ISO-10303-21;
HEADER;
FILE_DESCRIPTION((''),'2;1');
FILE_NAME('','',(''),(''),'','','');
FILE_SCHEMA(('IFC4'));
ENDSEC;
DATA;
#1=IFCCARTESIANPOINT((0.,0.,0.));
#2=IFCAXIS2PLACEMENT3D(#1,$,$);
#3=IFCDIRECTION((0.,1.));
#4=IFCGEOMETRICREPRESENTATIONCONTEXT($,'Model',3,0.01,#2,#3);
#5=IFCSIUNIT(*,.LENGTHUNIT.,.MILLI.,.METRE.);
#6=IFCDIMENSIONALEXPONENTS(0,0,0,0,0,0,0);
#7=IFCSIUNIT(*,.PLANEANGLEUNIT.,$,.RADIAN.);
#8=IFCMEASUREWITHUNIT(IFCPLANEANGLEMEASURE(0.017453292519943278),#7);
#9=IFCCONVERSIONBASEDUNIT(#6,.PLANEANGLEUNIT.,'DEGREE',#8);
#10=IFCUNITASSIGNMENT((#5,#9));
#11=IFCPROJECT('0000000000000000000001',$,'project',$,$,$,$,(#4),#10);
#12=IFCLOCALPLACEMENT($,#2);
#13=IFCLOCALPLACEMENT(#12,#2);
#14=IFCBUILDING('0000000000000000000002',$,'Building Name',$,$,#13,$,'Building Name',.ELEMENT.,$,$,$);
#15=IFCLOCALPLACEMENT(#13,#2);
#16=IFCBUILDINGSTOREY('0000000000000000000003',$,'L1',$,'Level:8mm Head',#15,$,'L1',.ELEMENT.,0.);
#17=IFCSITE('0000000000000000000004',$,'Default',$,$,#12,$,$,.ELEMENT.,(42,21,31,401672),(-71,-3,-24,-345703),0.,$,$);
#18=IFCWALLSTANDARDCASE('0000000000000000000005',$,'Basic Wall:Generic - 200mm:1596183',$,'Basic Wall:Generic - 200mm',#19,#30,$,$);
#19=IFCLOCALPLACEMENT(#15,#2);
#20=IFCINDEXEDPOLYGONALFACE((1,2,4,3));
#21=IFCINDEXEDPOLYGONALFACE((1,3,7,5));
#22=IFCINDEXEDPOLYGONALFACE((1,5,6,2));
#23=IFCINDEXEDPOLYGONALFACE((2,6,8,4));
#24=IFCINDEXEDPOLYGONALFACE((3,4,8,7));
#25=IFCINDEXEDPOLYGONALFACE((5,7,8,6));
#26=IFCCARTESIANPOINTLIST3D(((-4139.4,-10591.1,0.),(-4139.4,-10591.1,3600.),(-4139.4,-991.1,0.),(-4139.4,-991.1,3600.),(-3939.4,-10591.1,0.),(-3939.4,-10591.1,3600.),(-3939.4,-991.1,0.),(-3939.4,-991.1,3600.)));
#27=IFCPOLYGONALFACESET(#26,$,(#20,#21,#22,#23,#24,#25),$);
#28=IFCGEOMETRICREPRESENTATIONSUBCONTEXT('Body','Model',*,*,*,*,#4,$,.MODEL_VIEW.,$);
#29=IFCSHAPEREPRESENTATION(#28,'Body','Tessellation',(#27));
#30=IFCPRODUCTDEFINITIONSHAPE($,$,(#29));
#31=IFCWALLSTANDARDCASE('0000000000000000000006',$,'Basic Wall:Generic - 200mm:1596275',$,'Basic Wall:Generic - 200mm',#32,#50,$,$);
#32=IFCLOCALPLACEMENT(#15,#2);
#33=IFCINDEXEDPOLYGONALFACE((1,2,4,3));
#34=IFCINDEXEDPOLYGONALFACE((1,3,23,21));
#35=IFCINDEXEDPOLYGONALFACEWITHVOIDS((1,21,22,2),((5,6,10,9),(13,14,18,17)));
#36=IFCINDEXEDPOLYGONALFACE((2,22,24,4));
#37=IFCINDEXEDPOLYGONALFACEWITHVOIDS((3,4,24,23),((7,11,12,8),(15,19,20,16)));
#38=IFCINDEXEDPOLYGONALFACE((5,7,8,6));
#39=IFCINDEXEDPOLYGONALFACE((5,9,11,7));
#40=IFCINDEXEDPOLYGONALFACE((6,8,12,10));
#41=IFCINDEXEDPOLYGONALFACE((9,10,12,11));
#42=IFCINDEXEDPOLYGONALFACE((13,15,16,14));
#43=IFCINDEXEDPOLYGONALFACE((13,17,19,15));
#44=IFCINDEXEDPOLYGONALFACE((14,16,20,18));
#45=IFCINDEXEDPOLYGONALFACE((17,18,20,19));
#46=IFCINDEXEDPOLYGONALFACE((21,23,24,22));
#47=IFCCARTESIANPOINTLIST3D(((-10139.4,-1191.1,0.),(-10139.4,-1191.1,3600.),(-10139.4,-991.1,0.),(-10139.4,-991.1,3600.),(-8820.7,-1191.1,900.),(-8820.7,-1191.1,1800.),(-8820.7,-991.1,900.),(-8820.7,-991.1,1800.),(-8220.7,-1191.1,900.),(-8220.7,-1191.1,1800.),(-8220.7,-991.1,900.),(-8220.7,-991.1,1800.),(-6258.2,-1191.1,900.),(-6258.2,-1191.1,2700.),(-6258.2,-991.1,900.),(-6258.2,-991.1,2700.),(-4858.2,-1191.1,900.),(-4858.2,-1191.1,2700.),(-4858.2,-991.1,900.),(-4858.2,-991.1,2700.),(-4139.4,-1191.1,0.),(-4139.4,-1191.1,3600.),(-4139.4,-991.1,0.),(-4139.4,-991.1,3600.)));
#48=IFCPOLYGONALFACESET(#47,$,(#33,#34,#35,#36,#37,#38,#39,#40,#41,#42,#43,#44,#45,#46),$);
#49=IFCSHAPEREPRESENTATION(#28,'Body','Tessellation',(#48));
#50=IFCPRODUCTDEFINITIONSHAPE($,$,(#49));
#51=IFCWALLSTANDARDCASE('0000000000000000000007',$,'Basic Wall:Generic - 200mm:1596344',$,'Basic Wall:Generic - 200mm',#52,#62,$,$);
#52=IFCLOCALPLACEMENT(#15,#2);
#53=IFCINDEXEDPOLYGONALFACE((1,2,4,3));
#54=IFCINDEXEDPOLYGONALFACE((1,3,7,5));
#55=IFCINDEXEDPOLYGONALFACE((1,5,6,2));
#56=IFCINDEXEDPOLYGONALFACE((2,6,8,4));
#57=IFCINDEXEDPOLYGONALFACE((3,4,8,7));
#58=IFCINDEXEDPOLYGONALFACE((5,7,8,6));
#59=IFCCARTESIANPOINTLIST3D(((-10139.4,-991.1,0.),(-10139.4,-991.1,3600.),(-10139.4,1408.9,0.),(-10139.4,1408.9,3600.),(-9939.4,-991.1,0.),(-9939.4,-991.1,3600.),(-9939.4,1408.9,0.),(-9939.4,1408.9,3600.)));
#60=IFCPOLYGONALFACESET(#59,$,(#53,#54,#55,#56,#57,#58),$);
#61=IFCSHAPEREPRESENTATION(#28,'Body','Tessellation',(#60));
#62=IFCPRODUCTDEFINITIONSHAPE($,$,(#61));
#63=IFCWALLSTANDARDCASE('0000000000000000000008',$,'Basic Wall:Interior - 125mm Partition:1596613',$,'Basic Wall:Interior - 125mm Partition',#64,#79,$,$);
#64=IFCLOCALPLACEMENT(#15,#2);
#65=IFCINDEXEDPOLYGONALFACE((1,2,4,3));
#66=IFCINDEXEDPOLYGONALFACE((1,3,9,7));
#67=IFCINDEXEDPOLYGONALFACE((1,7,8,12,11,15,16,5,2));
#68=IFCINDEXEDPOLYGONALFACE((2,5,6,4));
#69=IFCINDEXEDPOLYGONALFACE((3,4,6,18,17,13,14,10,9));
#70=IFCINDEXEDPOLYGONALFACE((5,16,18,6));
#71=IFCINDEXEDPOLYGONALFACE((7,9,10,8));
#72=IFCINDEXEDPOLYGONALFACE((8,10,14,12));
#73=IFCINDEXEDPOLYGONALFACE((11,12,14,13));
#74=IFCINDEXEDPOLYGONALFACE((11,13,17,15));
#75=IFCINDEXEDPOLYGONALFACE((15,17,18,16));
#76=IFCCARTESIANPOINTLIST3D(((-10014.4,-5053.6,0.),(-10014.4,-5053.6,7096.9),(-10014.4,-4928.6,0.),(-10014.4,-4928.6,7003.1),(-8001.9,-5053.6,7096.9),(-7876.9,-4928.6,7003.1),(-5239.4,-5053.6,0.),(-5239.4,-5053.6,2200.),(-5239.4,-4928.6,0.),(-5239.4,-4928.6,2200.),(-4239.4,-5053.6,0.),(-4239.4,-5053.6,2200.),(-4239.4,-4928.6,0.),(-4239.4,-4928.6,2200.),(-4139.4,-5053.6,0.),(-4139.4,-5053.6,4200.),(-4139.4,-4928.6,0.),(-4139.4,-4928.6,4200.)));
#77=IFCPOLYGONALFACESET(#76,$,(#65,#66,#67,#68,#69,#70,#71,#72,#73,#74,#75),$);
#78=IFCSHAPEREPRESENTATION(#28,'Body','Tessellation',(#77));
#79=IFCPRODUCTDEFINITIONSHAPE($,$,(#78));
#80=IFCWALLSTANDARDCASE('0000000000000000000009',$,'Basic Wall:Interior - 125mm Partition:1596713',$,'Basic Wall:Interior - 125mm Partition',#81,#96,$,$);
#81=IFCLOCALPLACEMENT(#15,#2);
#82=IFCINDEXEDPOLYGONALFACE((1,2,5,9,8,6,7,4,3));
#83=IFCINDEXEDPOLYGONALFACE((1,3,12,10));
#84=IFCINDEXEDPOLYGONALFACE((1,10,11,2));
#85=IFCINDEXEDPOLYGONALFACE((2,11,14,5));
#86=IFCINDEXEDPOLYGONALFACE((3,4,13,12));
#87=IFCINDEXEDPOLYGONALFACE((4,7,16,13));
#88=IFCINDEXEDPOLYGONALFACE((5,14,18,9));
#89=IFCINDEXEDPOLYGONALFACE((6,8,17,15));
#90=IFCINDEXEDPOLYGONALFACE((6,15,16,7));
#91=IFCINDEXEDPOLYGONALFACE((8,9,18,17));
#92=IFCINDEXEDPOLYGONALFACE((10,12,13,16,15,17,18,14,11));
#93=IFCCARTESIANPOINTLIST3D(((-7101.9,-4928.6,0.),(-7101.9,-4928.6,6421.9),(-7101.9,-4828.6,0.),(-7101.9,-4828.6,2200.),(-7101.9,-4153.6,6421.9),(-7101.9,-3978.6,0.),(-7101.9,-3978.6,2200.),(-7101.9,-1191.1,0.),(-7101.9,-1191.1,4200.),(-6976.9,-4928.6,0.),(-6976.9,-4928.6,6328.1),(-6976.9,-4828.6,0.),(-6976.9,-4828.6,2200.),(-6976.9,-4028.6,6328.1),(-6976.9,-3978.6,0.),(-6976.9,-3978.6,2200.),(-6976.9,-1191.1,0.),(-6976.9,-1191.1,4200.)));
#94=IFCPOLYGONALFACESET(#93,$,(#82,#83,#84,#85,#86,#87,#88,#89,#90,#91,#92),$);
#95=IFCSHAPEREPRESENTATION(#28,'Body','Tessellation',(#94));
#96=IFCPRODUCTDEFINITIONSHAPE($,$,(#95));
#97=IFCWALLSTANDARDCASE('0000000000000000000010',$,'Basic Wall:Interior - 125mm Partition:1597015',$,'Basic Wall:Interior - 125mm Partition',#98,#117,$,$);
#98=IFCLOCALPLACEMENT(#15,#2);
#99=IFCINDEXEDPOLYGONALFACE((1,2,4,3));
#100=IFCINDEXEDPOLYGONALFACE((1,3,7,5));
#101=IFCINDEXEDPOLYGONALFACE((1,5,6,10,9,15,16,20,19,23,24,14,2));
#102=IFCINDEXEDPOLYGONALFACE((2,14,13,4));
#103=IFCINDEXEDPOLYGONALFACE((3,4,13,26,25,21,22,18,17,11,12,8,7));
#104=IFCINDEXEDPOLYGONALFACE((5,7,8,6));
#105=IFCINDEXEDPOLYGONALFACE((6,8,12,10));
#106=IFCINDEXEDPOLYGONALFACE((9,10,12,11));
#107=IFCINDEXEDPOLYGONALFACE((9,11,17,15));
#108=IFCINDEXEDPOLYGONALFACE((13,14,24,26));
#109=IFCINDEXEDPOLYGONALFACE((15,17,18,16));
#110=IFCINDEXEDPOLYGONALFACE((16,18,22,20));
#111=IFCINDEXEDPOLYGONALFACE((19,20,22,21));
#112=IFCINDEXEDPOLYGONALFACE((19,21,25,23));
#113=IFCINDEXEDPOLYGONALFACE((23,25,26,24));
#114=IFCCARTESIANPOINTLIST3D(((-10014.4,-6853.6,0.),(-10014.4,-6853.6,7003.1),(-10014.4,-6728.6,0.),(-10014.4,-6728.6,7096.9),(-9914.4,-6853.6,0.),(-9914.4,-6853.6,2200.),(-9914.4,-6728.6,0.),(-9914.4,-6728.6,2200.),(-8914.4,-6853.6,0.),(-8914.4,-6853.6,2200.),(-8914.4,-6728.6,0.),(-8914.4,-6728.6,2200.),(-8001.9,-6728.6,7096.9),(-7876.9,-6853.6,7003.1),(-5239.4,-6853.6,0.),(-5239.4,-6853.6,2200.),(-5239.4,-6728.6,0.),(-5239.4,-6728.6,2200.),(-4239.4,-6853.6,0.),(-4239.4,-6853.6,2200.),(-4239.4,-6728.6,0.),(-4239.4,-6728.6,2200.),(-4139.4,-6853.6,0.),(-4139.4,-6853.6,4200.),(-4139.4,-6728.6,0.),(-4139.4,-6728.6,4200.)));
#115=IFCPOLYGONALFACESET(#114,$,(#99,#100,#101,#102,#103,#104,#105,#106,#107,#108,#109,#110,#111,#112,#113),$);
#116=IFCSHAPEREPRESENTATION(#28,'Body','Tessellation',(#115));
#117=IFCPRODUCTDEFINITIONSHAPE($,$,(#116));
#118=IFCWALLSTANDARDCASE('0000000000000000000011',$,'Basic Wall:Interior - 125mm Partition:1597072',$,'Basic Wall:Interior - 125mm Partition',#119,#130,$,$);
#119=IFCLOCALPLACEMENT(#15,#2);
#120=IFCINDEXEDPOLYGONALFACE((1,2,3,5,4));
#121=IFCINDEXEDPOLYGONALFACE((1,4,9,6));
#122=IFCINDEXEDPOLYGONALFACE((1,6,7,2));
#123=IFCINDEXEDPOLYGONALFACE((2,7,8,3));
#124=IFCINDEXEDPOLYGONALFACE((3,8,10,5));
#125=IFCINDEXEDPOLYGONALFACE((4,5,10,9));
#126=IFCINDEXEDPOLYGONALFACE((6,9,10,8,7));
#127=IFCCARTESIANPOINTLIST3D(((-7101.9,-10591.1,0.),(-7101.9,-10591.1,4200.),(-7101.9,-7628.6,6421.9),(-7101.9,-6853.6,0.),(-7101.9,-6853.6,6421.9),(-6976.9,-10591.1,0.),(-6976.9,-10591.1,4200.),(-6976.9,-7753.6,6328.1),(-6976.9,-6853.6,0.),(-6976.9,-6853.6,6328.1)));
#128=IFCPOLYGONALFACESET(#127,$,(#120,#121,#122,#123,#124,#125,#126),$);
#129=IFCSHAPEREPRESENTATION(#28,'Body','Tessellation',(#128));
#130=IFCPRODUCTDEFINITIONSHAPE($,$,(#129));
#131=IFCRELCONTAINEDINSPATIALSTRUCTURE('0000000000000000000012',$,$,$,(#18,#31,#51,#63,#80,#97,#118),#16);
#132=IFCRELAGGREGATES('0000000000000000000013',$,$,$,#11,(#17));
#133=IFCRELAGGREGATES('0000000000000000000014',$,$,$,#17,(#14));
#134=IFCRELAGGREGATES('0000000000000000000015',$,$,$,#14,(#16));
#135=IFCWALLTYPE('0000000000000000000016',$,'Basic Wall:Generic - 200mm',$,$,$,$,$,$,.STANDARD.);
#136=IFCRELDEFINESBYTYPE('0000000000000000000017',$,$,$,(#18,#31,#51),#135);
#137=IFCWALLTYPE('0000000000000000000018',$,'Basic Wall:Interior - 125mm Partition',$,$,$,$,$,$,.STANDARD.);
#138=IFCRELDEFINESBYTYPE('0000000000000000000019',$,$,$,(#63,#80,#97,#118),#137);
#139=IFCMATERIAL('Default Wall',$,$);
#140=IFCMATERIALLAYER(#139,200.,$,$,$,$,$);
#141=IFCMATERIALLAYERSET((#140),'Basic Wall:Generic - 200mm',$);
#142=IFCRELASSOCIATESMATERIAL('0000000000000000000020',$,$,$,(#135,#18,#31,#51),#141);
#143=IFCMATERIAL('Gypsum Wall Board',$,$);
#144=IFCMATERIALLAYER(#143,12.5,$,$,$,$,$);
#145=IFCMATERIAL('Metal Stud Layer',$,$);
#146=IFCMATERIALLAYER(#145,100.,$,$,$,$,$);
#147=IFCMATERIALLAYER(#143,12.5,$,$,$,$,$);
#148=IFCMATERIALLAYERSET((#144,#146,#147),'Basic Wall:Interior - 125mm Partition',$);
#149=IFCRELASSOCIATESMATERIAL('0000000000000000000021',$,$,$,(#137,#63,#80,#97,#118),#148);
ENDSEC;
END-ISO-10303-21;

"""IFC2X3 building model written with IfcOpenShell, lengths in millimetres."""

from ifc_helpers import new_model, entity, si_unit, converted_unit, direction, frame, frame_2d, origin, place, context, subcontext, project, spatial, polyline, rectangle, extrude, clip, bounded_halfspace, material, layer, layer_set, layer_usage, type_object, element, save


model = new_model("IFC2X3")

# Units and contexts
model_context = context("Model", 3, precision=0.01, world=origin(), true_north=direction((0.0, 1.0)))
body_context = subcontext(model_context, "Body", "Model", "MODEL_VIEW")
ifc_project = project(units=[si_unit("LENGTHUNIT", "METRE", prefix="MILLI"), converted_unit("PLANEANGLEUNIT", "DEGREE", entity("IfcPlaneAngleMeasure", 0.017453292519943278), si_unit("PLANEANGLEUNIT", "RADIAN"), dimensions=[0, 0, 0, 0, 0, 0, 0])], contexts=[model_context])

# Site, building, storey
site_placement = place(None, origin())
site = spatial("IfcSite", under=ifc_project, at=site_placement, Name="Default", CompositionType="ELEMENT", RefLatitude=(42, 21, 31, 401672), RefLongitude=(-71, -3, -24, -345703), RefElevation=0.0)
building_placement = place(site_placement, origin())
building = spatial("IfcBuilding", under=site, at=building_placement, Name="Building Name", LongName="Building Name", CompositionType="ELEMENT")
storey_placement = place(building_placement, origin())
storey = spatial("IfcBuildingStorey", under=building, at=storey_placement, Name="L1", ObjectType="Level:8mm Head", LongName="L1", CompositionType="ELEMENT", Elevation=0.0)

# Wall
ifc_material_1 = material(Name="Default Wall")
ifc_layer_1 = layer(ifc_material_1, 200.0)
ifc_layer_set_1 = layer_set([ifc_layer_1], Name="Basic Wall:Generic - 200mm")
ifc_layer_usage_1 = layer_usage(ifc_layer_set_1, "AXIS2", "NEGATIVE", 100.0)
wall_type_1 = type_object("IfcWallType", Name="Basic Wall:Generic - 200mm", PredefinedType="STANDARD", material=ifc_layer_set_1)
wall_1_placement = place(storey_placement, frame((-4039.4, -10591.1, 0.0), z_axis=(0.0, 0.0, 1.0), x_axis=(0.0, 1.0, 0.0)))
element("IfcWallStandardCase", 1, at=wall_1_placement, inside=storey, type_object=wall_type_1, material=ifc_layer_usage_1, Name="Basic Wall:Generic - 200mm:1596183", ObjectType="Basic Wall:Generic - 200mm", context=body_context, shape_type="SweptSolid", body=[
    extrude(rectangle(XDim=9600.0, YDim=200.0, at=frame_2d((4800.0, 0.0), x_axis=(-1.0, 0.0))), origin(), (0.0, 0.0, 1.0), 3600.0),
])

# Wall, openings
wall_2_placement = place(storey_placement, frame((-4139.4, -1091.1, 0.0), z_axis=(0.0, 0.0, 1.0), x_axis=(-1.0, 0.0, 0.0)))
wall_2 = element("IfcWallStandardCase", 2, at=wall_2_placement, inside=storey, type_object=wall_type_1, material=ifc_layer_usage_1, Name="Basic Wall:Generic - 200mm:1596275", ObjectType="Basic Wall:Generic - 200mm", context=body_context, shape_type="SweptSolid", body=[
    extrude(rectangle(XDim=6000.0, YDim=200.0, at=frame_2d((3000.0, 0.0), x_axis=(-1.0, 0.0))), origin(), (0.0, 0.0, 1.0), 3600.0),
])
opening_1_placement = place(wall_2_placement, frame((2118.8, 100.0, 900.0)))
element("IfcOpeningElement", 3, at=opening_1_placement, cuts=wall_2, ObjectType="Opening", context=body_context, shape_type="SweptSolid", body=[
    extrude(rectangle(XDim=1800.0, YDim=1400.0, at=frame_2d((900.0, 700.0), x_axis=(-1.0, 0.0))), frame((0.0, 0.0, 0.0), z_axis=(0.0, -1.0, 0.0), x_axis=(0.0, 0.0, 1.0)), (0.0, 0.0, 1.0), 200.0),
])
opening_2_placement = place(wall_2_placement, frame((4081.3, -100.0, 900.0)))
element("IfcOpeningElement", 4, at=opening_2_placement, cuts=wall_2, ObjectType="Opening", context=body_context, shape_type="SweptSolid", body=[
    extrude(rectangle(XDim=900.0, YDim=600.0, at=frame_2d((450.0, 300.0), x_axis=(-1.0, 0.0))), frame((0.0, 0.0, 0.0), z_axis=(0.0, 1.0, 0.0), x_axis=(0.0, 0.0, 1.0)), (0.0, 0.0, 1.0), 200.0),
])

# Wall
wall_3_placement = place(storey_placement, frame((-10039.4, -991.1, 0.0), z_axis=(0.0, 0.0, 1.0), x_axis=(0.0, 1.0, 0.0)))
element("IfcWallStandardCase", 5, at=wall_3_placement, inside=storey, type_object=wall_type_1, material=ifc_layer_usage_1, Name="Basic Wall:Generic - 200mm:1596344", ObjectType="Basic Wall:Generic - 200mm", context=body_context, shape_type="SweptSolid", body=[
    extrude(rectangle(XDim=2400.0, YDim=200.0, at=frame_2d((1200.0, 0.0), x_axis=(-1.0, 0.0))), origin(), (0.0, 0.0, 1.0), 3600.0),
])

# Walls, openings
ifc_material_2 = material(Name="Gypsum Wall Board")
ifc_layer_2 = layer(ifc_material_2, 12.5)
ifc_material_3 = material(Name="Metal Stud Layer")
ifc_layer_3 = layer(ifc_material_3, 100.0)
ifc_layer_4 = layer(ifc_material_2, 12.5)
ifc_layer_set_2 = layer_set([ifc_layer_2, ifc_layer_3, ifc_layer_4], Name="Basic Wall:Interior - 125mm Partition")
ifc_layer_usage_2 = layer_usage(ifc_layer_set_2, "AXIS2", "NEGATIVE", 62.5)
wall_type_2 = type_object("IfcWallType", Name="Basic Wall:Interior - 125mm Partition", PredefinedType="STANDARD", material=ifc_layer_set_2)
wall_4_placement = place(storey_placement, frame((-10014.4, -4991.1, 0.0)))
wall_4 = element("IfcWallStandardCase", 6, at=wall_4_placement, inside=storey, type_object=wall_type_2, material=ifc_layer_usage_2, Name="Basic Wall:Interior - 125mm Partition:1596613", ObjectType="Basic Wall:Interior - 125mm Partition", context=body_context, shape_type="Clipping", body=[
    clip(clip(extrude(rectangle(XDim=125.0, YDim=5875.0, at=frame_2d((2937.5, 0.0), x_axis=(0.0, 1.0))), origin(), (0.0, 0.0, 1.0), 7096.9), bounded_halfspace(frame((5875.0, -62.5, 4200.0), z_axis=(0.6, 0.0, 0.8), x_axis=(0.0, 1.0, 0.0)), False, frame((5875.0, -62.5, 4200.0)), polyline([(0.0, 0.0), (0.0, 125.0), (-2837.5, 125.0), (-2962.5, 125.0), (-3737.5, 125.0), (-3862.5, 0.0), (0.0, 0.0)]))), bounded_halfspace(frame((0.0, 62.5, 7003.1), z_axis=(0.0, 0.6, 0.8), x_axis=(-1.0, 0.0, 0.0)), False, frame((0.0, 62.5, 7003.1)), polyline([(0.0, 0.0), (0.0, -125.0), (2012.5, -125.0), (2137.5, 0.0), (0.0, 0.0)]))),
])
opening_3_placement = place(wall_4_placement, frame((4775.0, -62.5, 0.0)))
element("IfcOpeningElement", 7, at=opening_3_placement, cuts=wall_4, ObjectType="Opening", context=body_context, shape_type="SweptSolid", body=[
    extrude(rectangle(XDim=2200.0, YDim=1000.0, at=frame_2d((1100.0, 500.0), x_axis=(1.0, 0.0))), frame((0.0, 0.0, 0.0), z_axis=(0.0, 1.0, 0.0), x_axis=(0.0, 0.0, 1.0)), (0.0, 0.0, 1.0), 125.0),
])
wall_5_placement = place(storey_placement, frame((-7039.4, -4928.6, 0.0), z_axis=(0.0, 0.0, 1.0), x_axis=(0.0, 1.0, 0.0)))
wall_5 = element("IfcWallStandardCase", 8, at=wall_5_placement, inside=storey, type_object=wall_type_2, material=ifc_layer_usage_2, Name="Basic Wall:Interior - 125mm Partition:1596713", ObjectType="Basic Wall:Interior - 125mm Partition", context=body_context, shape_type="Clipping", body=[
    clip(clip(extrude(rectangle(XDim=125.0, YDim=3737.5, at=frame_2d((1868.8, 0.0), x_axis=(0.0, 1.0))), origin(), (0.0, 0.0, 1.0), 6421.9), bounded_halfspace(frame((0.0, 62.5, 6421.9), z_axis=(0.0, -0.6, 0.8), x_axis=(1.0, 0.0, 0.0)), False, frame((0.0, 62.5, 6421.9)), polyline([(0.0, 0.0), (0.0, -125.0), (900.0, -125.0), (775.0, 0.0), (0.0, 0.0)]))), bounded_halfspace(frame((3737.5, -62.5, 4200.0), z_axis=(0.6, 0.0, 0.8), x_axis=(0.0, 1.0, 0.0)), False, frame((3737.5, -62.5, 4200.0)), polyline([(0.0, 0.0), (0.0, 125.0), (-2962.5, 125.0), (-2837.5, 0.0), (0.0, 0.0)]))),
])
opening_4_placement = place(wall_5_placement, frame((100.0, -62.5, 0.0)))
element("IfcOpeningElement", 9, at=opening_4_placement, cuts=wall_5, ObjectType="Opening", context=body_context, shape_type="SweptSolid", body=[
    extrude(rectangle(XDim=2200.0, YDim=850.0, at=frame_2d((1100.0, 425.0), x_axis=(1.0, 0.0))), frame((0.0, 0.0, 0.0), z_axis=(0.0, 1.0, 0.0), x_axis=(0.0, 0.0, 1.0)), (0.0, 0.0, 1.0), 125.0),
])

# Wall, openings
wall_6_placement = place(storey_placement, frame((-10014.4, -6791.1, 0.0)))
wall_6 = element("IfcWallStandardCase", 10, at=wall_6_placement, inside=storey, type_object=wall_type_2, material=ifc_layer_usage_2, Name="Basic Wall:Interior - 125mm Partition:1597015", ObjectType="Basic Wall:Interior - 125mm Partition", context=body_context, shape_type="Clipping", body=[
    clip(clip(extrude(rectangle(XDim=5875.0, YDim=125.0, at=frame_2d((2937.5, 0.0), x_axis=(-1.0, 0.0))), origin(), (0.0, 0.0, 1.0), 7096.9), bounded_halfspace(frame((0.0, 62.5, 7096.9), z_axis=(0.0, -0.6, 0.8), x_axis=(1.0, 0.0, 0.0)), False, frame((0.0, 62.5, 7096.9)), polyline([(0.0, 0.0), (0.0, -125.0), (2137.5, -125.0), (2012.5, 0.0), (0.0, 0.0)]))), bounded_halfspace(frame((5875.0, -62.5, 4200.0), z_axis=(0.6, 0.0, 0.8), x_axis=(0.0, 1.0, 0.0)), False, frame((5875.0, -62.5, 4200.0)), polyline([(0.0, 0.0), (0.0, 125.0), (-3862.5, 125.0), (-3737.5, 0.0), (-2962.5, 0.0), (-2837.5, 0.0), (0.0, 0.0)]))),
])
opening_5_placement = place(wall_6_placement, frame((5775.0, 62.5, 0.0)))
element("IfcOpeningElement", 11, at=opening_5_placement, cuts=wall_6, ObjectType="Opening", context=body_context, shape_type="SweptSolid", body=[
    extrude(rectangle(XDim=2200.0, YDim=1000.0, at=frame_2d((1100.0, 500.0), x_axis=(1.0, 0.0))), frame((0.0, 0.0, 0.0), z_axis=(0.0, -1.0, 0.0), x_axis=(0.0, 0.0, 1.0)), (0.0, 0.0, 1.0), 125.0),
])
opening_6_placement = place(wall_6_placement, frame((1100.0, 62.5, 0.0)))
element("IfcOpeningElement", 12, at=opening_6_placement, cuts=wall_6, ObjectType="Opening", context=body_context, shape_type="SweptSolid", body=[
    extrude(rectangle(XDim=2200.0, YDim=1000.0, at=frame_2d((1100.0, 500.0), x_axis=(1.0, 0.0))), frame((0.0, 0.0, 0.0), z_axis=(0.0, -1.0, 0.0), x_axis=(0.0, 0.0, 1.0)), (0.0, 0.0, 1.0), 125.0),
])

# Wall
wall_7_placement = place(storey_placement, frame((-7039.4, -6853.6, 0.0), z_axis=(0.0, 0.0, 1.0), x_axis=(0.0, -1.0, 0.0)))
element("IfcWallStandardCase", 13, at=wall_7_placement, inside=storey, type_object=wall_type_2, material=ifc_layer_usage_2, Name="Basic Wall:Interior - 125mm Partition:1597072", ObjectType="Basic Wall:Interior - 125mm Partition", context=body_context, shape_type="Clipping", body=[
    clip(clip(extrude(rectangle(XDim=3737.5, YDim=125.0, at=frame_2d((1868.8, 0.0), x_axis=(-1.0, 0.0))), origin(), (0.0, 0.0, 1.0), 6421.9), bounded_halfspace(frame((775.0, -62.5, 6421.9), z_axis=(0.6, 0.0, 0.8), x_axis=(0.0, 1.0, 0.0)), False, frame((775.0, -62.5, 6421.9)), polyline([(0.0, 0.0), (2962.5, 0.0), (2962.5, 125.0), (125.0, 125.0), (0.0, 0.0)]))), bounded_halfspace(frame((0.0, -62.5, 6421.9), z_axis=(0.0, 0.6, 0.8), x_axis=(-1.0, 0.0, 0.0)), False, frame((0.0, -62.5, 6421.9)), polyline([(0.0, 0.0), (775.0, 0.0), (900.0, 125.0), (0.0, 125.0), (0.0, 0.0)]))),
])

save(model, "model.ifc")
